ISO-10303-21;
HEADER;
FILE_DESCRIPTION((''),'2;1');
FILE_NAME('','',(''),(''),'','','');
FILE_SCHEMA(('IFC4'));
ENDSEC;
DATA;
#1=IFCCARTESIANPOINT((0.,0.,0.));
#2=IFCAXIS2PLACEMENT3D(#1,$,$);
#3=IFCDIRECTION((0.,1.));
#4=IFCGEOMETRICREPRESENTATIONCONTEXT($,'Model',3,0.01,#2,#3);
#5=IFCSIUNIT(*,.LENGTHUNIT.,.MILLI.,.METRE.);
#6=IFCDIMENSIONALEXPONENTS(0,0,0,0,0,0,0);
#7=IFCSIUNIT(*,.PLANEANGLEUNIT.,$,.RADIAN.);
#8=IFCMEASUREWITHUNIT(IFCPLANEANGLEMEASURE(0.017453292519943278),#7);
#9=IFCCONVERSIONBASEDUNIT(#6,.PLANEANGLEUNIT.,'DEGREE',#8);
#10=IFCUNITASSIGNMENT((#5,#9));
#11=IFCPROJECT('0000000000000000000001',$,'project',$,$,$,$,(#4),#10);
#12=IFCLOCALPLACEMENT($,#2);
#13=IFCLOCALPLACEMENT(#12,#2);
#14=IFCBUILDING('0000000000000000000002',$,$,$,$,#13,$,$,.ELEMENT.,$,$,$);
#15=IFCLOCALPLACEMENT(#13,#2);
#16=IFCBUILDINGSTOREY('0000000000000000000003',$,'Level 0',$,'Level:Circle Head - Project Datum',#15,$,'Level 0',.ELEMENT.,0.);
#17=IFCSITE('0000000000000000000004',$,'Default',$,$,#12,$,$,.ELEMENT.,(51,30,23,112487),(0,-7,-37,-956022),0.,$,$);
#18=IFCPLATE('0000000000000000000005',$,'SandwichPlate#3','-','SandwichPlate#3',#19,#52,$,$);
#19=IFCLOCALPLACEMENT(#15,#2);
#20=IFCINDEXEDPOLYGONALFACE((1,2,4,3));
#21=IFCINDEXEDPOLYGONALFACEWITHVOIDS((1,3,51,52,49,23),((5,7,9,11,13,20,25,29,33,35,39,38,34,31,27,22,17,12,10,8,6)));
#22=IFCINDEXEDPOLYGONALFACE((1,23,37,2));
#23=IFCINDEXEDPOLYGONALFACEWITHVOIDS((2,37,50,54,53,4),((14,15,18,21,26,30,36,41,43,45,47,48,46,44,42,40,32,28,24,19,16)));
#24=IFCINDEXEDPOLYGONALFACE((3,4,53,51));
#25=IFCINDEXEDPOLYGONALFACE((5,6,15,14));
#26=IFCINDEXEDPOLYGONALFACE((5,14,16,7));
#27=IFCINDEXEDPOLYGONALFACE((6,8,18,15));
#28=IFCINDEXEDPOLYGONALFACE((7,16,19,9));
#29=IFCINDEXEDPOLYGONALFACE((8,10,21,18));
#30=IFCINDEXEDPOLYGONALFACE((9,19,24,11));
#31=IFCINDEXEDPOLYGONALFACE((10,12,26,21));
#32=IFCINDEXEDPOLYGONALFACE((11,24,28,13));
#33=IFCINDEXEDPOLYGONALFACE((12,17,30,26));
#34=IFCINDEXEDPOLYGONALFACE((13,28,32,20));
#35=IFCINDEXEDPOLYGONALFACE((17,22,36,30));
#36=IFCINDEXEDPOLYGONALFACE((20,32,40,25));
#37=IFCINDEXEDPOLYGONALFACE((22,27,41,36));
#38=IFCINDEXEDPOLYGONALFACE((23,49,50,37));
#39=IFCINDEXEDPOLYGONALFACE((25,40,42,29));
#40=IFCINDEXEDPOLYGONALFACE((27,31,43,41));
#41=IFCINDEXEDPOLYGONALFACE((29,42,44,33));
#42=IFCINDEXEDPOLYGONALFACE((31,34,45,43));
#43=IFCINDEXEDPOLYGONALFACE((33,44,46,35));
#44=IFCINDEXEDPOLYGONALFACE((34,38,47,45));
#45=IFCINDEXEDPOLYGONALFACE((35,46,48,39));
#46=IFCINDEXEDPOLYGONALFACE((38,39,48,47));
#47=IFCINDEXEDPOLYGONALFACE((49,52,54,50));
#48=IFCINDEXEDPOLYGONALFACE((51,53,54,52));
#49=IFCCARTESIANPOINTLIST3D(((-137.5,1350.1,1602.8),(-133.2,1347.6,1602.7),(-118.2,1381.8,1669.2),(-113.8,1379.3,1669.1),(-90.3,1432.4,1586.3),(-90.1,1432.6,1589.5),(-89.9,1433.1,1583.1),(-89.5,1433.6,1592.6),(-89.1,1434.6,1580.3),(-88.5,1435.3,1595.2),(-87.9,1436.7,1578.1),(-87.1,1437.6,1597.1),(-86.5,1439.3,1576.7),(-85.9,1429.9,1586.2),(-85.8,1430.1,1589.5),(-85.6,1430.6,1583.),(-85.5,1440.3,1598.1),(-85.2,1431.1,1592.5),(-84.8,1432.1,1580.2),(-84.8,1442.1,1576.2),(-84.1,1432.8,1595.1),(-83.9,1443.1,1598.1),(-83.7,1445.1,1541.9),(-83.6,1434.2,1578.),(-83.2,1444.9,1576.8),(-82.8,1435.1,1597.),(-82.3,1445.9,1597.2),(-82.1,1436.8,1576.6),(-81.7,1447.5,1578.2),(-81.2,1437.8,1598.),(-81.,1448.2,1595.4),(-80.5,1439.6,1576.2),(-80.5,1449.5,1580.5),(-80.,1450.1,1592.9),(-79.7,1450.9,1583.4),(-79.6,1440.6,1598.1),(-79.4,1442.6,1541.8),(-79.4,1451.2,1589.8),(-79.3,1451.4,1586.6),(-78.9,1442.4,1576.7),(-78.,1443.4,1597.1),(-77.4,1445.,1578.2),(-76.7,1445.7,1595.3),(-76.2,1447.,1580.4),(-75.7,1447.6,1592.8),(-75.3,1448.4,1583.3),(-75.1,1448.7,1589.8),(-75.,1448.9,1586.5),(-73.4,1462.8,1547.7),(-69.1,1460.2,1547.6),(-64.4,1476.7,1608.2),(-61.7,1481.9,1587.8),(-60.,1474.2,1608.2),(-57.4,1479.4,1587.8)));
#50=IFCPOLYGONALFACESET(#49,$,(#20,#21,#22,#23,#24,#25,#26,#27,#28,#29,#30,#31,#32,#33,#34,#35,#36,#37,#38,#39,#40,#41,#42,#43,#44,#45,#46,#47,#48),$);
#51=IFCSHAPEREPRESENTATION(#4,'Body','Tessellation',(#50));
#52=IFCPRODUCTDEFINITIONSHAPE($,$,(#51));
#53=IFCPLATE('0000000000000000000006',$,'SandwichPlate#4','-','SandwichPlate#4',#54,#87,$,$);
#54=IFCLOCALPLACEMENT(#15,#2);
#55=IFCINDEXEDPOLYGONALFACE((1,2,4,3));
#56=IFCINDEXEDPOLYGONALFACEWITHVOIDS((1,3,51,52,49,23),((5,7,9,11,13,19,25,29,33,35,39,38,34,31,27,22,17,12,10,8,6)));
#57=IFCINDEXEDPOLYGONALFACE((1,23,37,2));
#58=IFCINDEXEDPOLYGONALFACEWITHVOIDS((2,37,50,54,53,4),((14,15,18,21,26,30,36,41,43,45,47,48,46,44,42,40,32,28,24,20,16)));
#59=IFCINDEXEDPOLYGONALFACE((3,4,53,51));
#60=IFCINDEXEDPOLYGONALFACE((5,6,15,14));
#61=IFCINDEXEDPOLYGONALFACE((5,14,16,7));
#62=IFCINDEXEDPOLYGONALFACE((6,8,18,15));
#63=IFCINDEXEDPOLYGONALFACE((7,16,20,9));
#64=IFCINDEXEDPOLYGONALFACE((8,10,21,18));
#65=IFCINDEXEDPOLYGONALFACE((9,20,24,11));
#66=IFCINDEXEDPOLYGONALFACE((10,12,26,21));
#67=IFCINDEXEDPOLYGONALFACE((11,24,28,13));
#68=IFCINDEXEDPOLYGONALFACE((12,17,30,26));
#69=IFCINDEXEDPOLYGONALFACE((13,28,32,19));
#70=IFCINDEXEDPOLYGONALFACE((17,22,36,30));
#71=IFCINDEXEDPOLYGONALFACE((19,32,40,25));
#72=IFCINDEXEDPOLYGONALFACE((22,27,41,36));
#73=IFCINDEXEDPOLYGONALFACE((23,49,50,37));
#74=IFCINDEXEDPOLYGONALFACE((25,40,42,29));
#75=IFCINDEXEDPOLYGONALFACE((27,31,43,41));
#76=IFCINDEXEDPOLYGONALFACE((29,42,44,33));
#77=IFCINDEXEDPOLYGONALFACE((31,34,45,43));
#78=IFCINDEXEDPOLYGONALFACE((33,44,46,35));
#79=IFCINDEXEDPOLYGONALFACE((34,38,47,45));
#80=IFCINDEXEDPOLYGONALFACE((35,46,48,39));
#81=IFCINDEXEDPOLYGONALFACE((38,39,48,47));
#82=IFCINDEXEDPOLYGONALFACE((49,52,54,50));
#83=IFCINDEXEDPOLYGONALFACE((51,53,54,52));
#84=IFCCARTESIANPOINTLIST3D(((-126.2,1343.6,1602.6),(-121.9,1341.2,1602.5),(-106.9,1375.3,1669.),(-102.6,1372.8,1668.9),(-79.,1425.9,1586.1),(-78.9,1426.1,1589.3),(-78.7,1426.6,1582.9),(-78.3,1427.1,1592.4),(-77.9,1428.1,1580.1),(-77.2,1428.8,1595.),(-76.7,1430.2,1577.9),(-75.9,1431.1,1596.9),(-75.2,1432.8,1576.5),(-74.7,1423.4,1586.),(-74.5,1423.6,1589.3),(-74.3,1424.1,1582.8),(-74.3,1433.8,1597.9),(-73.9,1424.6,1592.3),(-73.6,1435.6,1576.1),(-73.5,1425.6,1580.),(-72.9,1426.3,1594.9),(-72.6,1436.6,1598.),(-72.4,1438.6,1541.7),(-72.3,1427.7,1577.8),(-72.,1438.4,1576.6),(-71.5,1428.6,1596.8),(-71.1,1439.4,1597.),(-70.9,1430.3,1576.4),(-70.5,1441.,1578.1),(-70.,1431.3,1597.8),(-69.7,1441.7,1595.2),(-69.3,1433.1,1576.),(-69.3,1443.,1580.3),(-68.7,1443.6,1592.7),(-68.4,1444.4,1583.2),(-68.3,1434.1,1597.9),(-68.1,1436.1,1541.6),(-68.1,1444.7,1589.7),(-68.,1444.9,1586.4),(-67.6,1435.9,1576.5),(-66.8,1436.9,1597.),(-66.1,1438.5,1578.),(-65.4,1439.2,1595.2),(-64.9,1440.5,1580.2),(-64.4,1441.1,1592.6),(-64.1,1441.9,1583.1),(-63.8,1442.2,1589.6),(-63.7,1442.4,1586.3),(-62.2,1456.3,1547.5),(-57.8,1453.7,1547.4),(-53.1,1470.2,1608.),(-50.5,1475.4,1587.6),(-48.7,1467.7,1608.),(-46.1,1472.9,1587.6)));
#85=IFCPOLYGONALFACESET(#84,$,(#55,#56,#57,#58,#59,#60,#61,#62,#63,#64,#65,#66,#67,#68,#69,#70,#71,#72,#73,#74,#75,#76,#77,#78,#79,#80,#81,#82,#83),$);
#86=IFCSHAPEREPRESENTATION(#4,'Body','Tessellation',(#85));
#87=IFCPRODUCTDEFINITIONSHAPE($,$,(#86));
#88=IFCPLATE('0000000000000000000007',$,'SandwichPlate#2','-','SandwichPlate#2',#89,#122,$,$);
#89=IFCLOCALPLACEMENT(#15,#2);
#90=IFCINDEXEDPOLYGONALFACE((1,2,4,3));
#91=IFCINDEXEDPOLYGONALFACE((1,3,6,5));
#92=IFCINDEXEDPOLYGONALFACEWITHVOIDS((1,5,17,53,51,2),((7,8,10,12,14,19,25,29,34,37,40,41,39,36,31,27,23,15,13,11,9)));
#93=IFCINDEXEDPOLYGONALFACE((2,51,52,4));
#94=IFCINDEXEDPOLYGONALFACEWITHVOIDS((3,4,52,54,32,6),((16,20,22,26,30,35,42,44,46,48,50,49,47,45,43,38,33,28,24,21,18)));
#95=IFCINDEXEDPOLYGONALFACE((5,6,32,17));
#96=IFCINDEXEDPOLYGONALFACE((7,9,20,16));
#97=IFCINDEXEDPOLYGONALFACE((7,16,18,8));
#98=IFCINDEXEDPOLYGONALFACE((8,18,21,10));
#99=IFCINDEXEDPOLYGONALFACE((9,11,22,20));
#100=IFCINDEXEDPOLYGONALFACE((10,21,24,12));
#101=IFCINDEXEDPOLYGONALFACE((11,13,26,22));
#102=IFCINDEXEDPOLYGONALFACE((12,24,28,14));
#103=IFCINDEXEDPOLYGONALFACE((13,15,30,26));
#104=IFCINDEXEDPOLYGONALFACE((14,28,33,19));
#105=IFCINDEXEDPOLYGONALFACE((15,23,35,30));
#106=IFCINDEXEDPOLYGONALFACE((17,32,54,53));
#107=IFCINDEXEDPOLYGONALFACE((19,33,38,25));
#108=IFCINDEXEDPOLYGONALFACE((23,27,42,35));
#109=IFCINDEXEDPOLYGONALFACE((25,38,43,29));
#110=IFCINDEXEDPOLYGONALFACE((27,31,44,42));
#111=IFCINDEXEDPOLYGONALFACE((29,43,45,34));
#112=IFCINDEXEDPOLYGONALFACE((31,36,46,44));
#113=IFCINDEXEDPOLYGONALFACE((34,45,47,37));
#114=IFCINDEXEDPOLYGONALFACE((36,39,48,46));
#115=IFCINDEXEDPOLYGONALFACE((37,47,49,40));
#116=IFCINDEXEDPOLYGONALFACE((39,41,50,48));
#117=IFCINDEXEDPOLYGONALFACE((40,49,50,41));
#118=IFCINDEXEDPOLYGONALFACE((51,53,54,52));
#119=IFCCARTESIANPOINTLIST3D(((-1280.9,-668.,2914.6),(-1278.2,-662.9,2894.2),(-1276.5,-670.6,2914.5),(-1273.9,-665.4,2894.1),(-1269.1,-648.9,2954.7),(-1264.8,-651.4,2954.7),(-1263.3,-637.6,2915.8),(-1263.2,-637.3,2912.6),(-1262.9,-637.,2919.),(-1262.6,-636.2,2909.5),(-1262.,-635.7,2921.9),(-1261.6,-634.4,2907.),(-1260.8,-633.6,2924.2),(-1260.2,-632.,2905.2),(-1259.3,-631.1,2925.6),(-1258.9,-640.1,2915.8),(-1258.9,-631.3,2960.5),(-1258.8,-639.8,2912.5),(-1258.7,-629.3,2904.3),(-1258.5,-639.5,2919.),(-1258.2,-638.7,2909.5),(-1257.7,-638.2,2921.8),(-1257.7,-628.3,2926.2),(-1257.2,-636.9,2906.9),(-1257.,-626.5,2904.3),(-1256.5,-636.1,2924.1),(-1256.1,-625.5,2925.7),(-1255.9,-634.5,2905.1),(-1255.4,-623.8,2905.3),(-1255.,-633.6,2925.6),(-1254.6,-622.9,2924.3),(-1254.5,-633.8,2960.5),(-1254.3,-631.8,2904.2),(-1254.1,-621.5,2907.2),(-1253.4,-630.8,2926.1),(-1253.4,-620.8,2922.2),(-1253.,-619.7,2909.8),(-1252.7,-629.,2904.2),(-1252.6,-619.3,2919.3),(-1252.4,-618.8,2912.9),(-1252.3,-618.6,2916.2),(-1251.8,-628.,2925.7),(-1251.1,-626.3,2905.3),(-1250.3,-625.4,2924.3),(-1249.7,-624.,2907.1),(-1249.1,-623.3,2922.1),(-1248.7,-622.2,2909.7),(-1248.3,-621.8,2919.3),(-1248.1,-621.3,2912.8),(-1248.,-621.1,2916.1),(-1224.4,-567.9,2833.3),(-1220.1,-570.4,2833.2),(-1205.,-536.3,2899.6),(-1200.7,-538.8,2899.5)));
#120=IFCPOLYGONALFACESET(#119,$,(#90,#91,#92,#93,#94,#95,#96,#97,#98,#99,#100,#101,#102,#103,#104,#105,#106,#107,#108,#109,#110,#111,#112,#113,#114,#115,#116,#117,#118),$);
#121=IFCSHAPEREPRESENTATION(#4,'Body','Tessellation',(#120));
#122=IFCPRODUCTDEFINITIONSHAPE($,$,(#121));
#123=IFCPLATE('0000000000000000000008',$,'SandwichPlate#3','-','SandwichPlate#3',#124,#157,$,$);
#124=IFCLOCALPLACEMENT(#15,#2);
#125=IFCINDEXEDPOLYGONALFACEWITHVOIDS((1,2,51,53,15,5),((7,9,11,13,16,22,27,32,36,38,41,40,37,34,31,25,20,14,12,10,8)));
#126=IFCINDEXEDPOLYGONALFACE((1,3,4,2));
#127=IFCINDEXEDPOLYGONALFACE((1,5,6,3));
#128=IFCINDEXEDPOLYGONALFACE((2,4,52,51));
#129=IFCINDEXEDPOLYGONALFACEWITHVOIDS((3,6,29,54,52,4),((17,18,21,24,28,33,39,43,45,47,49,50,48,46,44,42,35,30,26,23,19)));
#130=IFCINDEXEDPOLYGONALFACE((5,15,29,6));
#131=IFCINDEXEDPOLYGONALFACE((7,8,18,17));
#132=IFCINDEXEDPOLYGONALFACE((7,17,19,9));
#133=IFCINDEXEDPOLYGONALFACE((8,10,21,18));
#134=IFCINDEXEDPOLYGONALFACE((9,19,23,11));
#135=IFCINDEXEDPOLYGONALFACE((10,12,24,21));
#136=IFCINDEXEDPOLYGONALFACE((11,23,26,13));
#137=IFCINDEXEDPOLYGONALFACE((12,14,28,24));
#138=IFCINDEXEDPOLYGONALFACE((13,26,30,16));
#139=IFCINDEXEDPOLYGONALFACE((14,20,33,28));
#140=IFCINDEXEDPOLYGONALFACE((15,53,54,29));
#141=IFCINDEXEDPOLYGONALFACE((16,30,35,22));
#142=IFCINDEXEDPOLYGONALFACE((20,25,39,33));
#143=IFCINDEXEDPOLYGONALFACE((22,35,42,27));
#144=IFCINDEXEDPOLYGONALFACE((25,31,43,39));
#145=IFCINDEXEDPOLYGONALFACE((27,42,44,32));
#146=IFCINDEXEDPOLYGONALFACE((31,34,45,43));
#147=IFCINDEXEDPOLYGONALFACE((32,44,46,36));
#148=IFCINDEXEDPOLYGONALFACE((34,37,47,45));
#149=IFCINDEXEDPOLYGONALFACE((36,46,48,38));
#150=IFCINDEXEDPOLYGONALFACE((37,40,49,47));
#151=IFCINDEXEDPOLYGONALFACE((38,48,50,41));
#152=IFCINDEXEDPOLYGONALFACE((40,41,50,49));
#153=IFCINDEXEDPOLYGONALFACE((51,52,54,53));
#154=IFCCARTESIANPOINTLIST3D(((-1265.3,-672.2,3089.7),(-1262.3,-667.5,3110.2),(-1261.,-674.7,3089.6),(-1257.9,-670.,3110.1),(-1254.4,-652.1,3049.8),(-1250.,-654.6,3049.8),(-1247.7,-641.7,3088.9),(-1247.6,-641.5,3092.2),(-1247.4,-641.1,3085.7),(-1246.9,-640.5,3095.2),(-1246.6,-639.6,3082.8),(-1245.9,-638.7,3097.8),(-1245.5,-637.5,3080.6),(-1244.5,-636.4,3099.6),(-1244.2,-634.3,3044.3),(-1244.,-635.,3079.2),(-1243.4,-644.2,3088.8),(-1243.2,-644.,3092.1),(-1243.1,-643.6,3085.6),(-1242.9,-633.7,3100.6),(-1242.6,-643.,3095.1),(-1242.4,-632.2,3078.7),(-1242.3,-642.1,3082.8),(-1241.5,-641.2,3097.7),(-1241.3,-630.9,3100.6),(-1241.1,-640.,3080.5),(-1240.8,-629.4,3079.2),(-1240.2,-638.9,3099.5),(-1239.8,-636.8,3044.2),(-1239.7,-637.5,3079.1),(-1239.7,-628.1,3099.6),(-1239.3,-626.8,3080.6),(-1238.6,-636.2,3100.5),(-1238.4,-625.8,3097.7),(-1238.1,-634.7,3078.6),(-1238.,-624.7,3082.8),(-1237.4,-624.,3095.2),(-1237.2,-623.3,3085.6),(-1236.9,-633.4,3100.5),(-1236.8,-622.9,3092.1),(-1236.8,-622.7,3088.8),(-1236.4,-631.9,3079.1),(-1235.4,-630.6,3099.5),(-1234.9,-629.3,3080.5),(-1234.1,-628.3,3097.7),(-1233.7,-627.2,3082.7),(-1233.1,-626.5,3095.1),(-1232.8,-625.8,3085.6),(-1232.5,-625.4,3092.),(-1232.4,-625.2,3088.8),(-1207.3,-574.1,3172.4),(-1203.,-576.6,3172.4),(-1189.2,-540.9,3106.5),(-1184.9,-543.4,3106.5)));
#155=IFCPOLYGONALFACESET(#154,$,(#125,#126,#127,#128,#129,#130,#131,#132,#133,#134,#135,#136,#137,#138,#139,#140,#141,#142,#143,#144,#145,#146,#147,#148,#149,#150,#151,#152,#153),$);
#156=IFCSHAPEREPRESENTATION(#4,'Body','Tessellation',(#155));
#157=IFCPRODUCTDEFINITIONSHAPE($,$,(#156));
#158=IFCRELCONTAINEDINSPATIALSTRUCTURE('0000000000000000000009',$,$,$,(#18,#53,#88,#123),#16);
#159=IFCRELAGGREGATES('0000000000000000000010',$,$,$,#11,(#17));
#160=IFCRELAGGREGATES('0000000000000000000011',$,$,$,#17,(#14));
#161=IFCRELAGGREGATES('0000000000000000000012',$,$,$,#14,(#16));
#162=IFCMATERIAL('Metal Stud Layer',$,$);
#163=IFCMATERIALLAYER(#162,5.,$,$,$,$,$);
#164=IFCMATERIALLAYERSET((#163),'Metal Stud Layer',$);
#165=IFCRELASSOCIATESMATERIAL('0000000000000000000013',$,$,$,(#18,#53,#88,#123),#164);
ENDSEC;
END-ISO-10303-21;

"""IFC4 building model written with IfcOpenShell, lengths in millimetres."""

from ifc_helpers import new_model, entity, si_unit, converted_unit, direction, frame, origin, origin_with_axes, origin_2d_with_axis, place, context, project, spatial, polyline, circle, outline, extrude, material, layer, layer_set, element, save


model = new_model("IFC4")

# Units and contexts
model_context = context("Model", 3, precision=0.01, world=origin(), true_north=direction((0.0, 1.0)))
ifc_project = project(units=[si_unit("LENGTHUNIT", "METRE", prefix="MILLI"), converted_unit("PLANEANGLEUNIT", "DEGREE", entity("IfcPlaneAngleMeasure", 0.017453292519943278), si_unit("PLANEANGLEUNIT", "RADIAN"), dimensions=[0, 0, 0, 0, 0, 0, 0])], contexts=[model_context])

# Site, building, storey
site_placement = place(None, origin())
site = spatial("IfcSite", under=ifc_project, at=site_placement, Name="Default", CompositionType="ELEMENT", RefLatitude=(51, 30, 23, 112487), RefLongitude=(0, -7, -37, -956022), RefElevation=0.0)
building_placement = place(site_placement, origin())
building = spatial("IfcBuilding", under=site, at=building_placement, CompositionType="ELEMENT")
storey_placement = place(building_placement, origin())
storey = spatial("IfcBuildingStorey", under=building, at=storey_placement, Name="Level 0", ObjectType="Level:Circle Head - Project Datum", LongName="Level 0", CompositionType="ELEMENT", Elevation=0.0)

# Plates, openings
ifc_material = material(Name="Metal Stud Layer")
ifc_layer_1 = layer(ifc_material, 5.0)
ifc_layer_set_1 = layer_set([ifc_layer_1], Name="Metal Stud Layer")
plate_1_placement = place(storey_placement, frame((-77.2, 1456.5, 1534.6), z_axis=(0.865935, -0.499948, -0.014432), x_axis=(0.254617, 0.415806, 0.873084)))
plate_1 = element("IfcPlate", 1, at=plate_1_placement, inside=storey, material=ifc_layer_set_1, Name="SandwichPlate#3", Description="-", ObjectType="SandwichPlate#3", context=model_context, shape_type="SweptSolid", body=[
    extrude(outline(polyline([(0.0, 0.0), (76.0, 0.0), (76.0, 140.0), (0.0, 140.0), (0.0, 0.0)])), origin_with_axes(), (0.0, 0.0, 1.0), 5.0),
])
opening_1_placement = place(plate_1_placement, frame((0.0, 0.0, 0.0), z_axis=(0.0, 0.0, 1.0), x_axis=(1.0, 0.0, 0.0)))
element("IfcOpeningElement", 2, at=opening_1_placement, cuts=plate_1, ObjectType="Opening", context=model_context, shape_type="SweptSolid", body=[
    extrude(outline(polyline([(0.0, 0.0), (15.0, 0.0), (0.0, 15.0), (0.0, 0.0)])), origin(), (0.0, 0.0, 1.0), 5.0),
])
opening_2_placement = place(plate_1_placement, frame((0.0, 0.0, 0.0), z_axis=(0.0, 0.0, 1.0), x_axis=(1.0, 0.0, 0.0)))
element("IfcOpeningElement", 3, at=opening_2_placement, cuts=plate_1, ObjectType="Opening", context=model_context, shape_type="SweptSolid", body=[
    extrude(outline(polyline([(76.0, 0.0), (76.0, 15.0), (61.0, 0.0), (76.0, 0.0)])), origin(), (0.0, 0.0, 1.0), 5.0),
])
opening_3_placement = place(plate_1_placement, frame((38.0, 40.0, -0.5), z_axis=(0.0, 0.0, 1.0), x_axis=(0.0, 1.0, 0.0)))
element("IfcOpeningElement", 4, at=opening_3_placement, cuts=plate_1, ObjectType="Opening", context=model_context, shape_type="SweptSolid", body=[
    extrude(circle(Radius=11.0, at=origin_2d_with_axis()), origin(), (0.0, 0.0, 1.0), 6.0),
])
plate_2_placement = place(storey_placement, frame((-66.0, 1450.0, 1534.4), z_axis=(0.865935, -0.499948, -0.014432), x_axis=(0.254617, 0.415806, 0.873084)))
plate_2 = element("IfcPlate", 5, at=plate_2_placement, inside=storey, material=ifc_layer_set_1, Name="SandwichPlate#4", Description="-", ObjectType="SandwichPlate#4", context=model_context, shape_type="SweptSolid", body=[
    extrude(outline(polyline([(0.0, 0.0), (76.0, 0.0), (76.0, 140.0), (0.0, 140.0), (0.0, 0.0)])), origin_with_axes(), (0.0, 0.0, 1.0), 5.0),
])
opening_4_placement = place(plate_2_placement, frame((0.0, 0.0, 0.0), z_axis=(0.0, 0.0, 1.0), x_axis=(1.0, 0.0, 0.0)))
element("IfcOpeningElement", 6, at=opening_4_placement, cuts=plate_2, ObjectType="Opening", context=model_context, shape_type="SweptSolid", body=[
    extrude(outline(polyline([(0.0, 0.0), (15.0, 0.0), (0.0, 15.0), (0.0, 0.0)])), origin(), (0.0, 0.0, 1.0), 5.0),
])
opening_5_placement = place(plate_2_placement, frame((0.0, 0.0, 0.0), z_axis=(0.0, 0.0, 1.0), x_axis=(1.0, 0.0, 0.0)))
element("IfcOpeningElement", 7, at=opening_5_placement, cuts=plate_2, ObjectType="Opening", context=model_context, shape_type="SweptSolid", body=[
    extrude(outline(polyline([(76.0, 0.0), (76.0, 15.0), (61.0, 0.0), (76.0, 0.0)])), origin(), (0.0, 0.0, 1.0), 5.0),
])
opening_6_placement = place(plate_2_placement, frame((38.0, 40.0, -0.5), z_axis=(0.0, 0.0, 1.0), x_axis=(0.0, 1.0, 0.0)))
element("IfcOpeningElement", 8, at=opening_6_placement, cuts=plate_2, ObjectType="Opening", context=model_context, shape_type="SweptSolid", body=[
    extrude(circle(Radius=11.0, at=origin_2d_with_axis()), origin(), (0.0, 0.0, 1.0), 6.0),
])
plate_3_placement = place(storey_placement, frame((-1280.3, -676.8, 2901.4), z_axis=(-0.865935, 0.499948, 0.014432), x_axis=(0.254617, 0.415806, 0.873084)))
plate_3 = element("IfcPlate", 9, at=plate_3_placement, inside=storey, material=ifc_layer_set_1, Name="SandwichPlate#2", Description="-", ObjectType="SandwichPlate#2", context=model_context, shape_type="SweptSolid", body=[
    extrude(outline(polyline([(0.0, 0.0), (76.0, 0.0), (76.0, 140.0), (0.0, 140.0), (0.0, 0.0)])), origin_with_axes(), (0.0, 0.0, 1.0), 5.0),
])
opening_7_placement = place(plate_3_placement, frame((0.0, 0.0, 0.0), z_axis=(0.0, 0.0, 1.0), x_axis=(1.0, 0.0, 0.0)))
element("IfcOpeningElement", 10, at=opening_7_placement, cuts=plate_3, ObjectType="Opening", context=model_context, shape_type="SweptSolid", body=[
    extrude(outline(polyline([(0.0, 0.0), (15.0, 0.0), (0.0, 15.0), (0.0, 0.0)])), origin(), (0.0, 0.0, 1.0), 5.0),
])
opening_8_placement = place(plate_3_placement, frame((0.0, 0.0, 0.0), z_axis=(0.0, 0.0, 1.0), x_axis=(1.0, 0.0, 0.0)))
element("IfcOpeningElement", 11, at=opening_8_placement, cuts=plate_3, ObjectType="Opening", context=model_context, shape_type="SweptSolid", body=[
    extrude(outline(polyline([(76.0, 0.0), (76.0, 15.0), (61.0, 0.0), (76.0, 0.0)])), origin(), (0.0, 0.0, 1.0), 5.0),
])
opening_9_placement = place(plate_3_placement, frame((38.0, 40.0, -0.5), z_axis=(0.0, 0.0, 1.0), x_axis=(0.0, 1.0, 0.0)))
element("IfcOpeningElement", 12, at=opening_9_placement, cuts=plate_3, ObjectType="Opening", context=model_context, shape_type="SweptSolid", body=[
    extrude(circle(Radius=11.0, at=origin_2d_with_axis()), origin(), (0.0, 0.0, 1.0), 6.0),
])
plate_4_placement = place(storey_placement, frame((-1246.4, -648.0, 3036.7), z_axis=(-0.865935, 0.499948, 0.014432), x_axis=(-0.238139, -0.437501, 0.867112)))
plate_4 = element("IfcPlate", 13, at=plate_4_placement, inside=storey, material=ifc_layer_set_1, Name="SandwichPlate#3", Description="-", ObjectType="SandwichPlate#3", context=model_context, shape_type="SweptSolid", body=[
    extrude(outline(polyline([(0.0, 0.0), (76.0, 0.0), (76.0, 140.0), (0.0, 140.0), (0.0, 0.0)])), origin_with_axes(), (0.0, 0.0, 1.0), 5.0),
])
opening_10_placement = place(plate_4_placement, frame((0.0, 0.0, 0.0), z_axis=(0.0, 0.0, 1.0), x_axis=(1.0, 0.0, 0.0)))
element("IfcOpeningElement", 14, at=opening_10_placement, cuts=plate_4, ObjectType="Opening", context=model_context, shape_type="SweptSolid", body=[
    extrude(outline(polyline([(0.0, 0.0), (15.0, 0.0), (0.0, 15.0), (0.0, 0.0)])), origin(), (0.0, 0.0, 1.0), 5.0),
])
opening_11_placement = place(plate_4_placement, frame((0.0, 0.0, 0.0), z_axis=(0.0, 0.0, 1.0), x_axis=(1.0, 0.0, 0.0)))
element("IfcOpeningElement", 15, at=opening_11_placement, cuts=plate_4, ObjectType="Opening", context=model_context, shape_type="SweptSolid", body=[
    extrude(outline(polyline([(76.0, 0.0), (76.0, 15.0), (61.0, 0.0), (76.0, 0.0)])), origin(), (0.0, 0.0, 1.0), 5.0),
])
opening_12_placement = place(plate_4_placement, frame((38.0, 40.0, -0.5), z_axis=(0.0, 0.0, 1.0), x_axis=(0.0, 1.0, 0.0)))
element("IfcOpeningElement", 16, at=opening_12_placement, cuts=plate_4, ObjectType="Opening", context=model_context, shape_type="SweptSolid", body=[
    extrude(circle(Radius=11.0, at=origin_2d_with_axis()), origin(), (0.0, 0.0, 1.0), 6.0),
])

save(model, "model.ifc")
